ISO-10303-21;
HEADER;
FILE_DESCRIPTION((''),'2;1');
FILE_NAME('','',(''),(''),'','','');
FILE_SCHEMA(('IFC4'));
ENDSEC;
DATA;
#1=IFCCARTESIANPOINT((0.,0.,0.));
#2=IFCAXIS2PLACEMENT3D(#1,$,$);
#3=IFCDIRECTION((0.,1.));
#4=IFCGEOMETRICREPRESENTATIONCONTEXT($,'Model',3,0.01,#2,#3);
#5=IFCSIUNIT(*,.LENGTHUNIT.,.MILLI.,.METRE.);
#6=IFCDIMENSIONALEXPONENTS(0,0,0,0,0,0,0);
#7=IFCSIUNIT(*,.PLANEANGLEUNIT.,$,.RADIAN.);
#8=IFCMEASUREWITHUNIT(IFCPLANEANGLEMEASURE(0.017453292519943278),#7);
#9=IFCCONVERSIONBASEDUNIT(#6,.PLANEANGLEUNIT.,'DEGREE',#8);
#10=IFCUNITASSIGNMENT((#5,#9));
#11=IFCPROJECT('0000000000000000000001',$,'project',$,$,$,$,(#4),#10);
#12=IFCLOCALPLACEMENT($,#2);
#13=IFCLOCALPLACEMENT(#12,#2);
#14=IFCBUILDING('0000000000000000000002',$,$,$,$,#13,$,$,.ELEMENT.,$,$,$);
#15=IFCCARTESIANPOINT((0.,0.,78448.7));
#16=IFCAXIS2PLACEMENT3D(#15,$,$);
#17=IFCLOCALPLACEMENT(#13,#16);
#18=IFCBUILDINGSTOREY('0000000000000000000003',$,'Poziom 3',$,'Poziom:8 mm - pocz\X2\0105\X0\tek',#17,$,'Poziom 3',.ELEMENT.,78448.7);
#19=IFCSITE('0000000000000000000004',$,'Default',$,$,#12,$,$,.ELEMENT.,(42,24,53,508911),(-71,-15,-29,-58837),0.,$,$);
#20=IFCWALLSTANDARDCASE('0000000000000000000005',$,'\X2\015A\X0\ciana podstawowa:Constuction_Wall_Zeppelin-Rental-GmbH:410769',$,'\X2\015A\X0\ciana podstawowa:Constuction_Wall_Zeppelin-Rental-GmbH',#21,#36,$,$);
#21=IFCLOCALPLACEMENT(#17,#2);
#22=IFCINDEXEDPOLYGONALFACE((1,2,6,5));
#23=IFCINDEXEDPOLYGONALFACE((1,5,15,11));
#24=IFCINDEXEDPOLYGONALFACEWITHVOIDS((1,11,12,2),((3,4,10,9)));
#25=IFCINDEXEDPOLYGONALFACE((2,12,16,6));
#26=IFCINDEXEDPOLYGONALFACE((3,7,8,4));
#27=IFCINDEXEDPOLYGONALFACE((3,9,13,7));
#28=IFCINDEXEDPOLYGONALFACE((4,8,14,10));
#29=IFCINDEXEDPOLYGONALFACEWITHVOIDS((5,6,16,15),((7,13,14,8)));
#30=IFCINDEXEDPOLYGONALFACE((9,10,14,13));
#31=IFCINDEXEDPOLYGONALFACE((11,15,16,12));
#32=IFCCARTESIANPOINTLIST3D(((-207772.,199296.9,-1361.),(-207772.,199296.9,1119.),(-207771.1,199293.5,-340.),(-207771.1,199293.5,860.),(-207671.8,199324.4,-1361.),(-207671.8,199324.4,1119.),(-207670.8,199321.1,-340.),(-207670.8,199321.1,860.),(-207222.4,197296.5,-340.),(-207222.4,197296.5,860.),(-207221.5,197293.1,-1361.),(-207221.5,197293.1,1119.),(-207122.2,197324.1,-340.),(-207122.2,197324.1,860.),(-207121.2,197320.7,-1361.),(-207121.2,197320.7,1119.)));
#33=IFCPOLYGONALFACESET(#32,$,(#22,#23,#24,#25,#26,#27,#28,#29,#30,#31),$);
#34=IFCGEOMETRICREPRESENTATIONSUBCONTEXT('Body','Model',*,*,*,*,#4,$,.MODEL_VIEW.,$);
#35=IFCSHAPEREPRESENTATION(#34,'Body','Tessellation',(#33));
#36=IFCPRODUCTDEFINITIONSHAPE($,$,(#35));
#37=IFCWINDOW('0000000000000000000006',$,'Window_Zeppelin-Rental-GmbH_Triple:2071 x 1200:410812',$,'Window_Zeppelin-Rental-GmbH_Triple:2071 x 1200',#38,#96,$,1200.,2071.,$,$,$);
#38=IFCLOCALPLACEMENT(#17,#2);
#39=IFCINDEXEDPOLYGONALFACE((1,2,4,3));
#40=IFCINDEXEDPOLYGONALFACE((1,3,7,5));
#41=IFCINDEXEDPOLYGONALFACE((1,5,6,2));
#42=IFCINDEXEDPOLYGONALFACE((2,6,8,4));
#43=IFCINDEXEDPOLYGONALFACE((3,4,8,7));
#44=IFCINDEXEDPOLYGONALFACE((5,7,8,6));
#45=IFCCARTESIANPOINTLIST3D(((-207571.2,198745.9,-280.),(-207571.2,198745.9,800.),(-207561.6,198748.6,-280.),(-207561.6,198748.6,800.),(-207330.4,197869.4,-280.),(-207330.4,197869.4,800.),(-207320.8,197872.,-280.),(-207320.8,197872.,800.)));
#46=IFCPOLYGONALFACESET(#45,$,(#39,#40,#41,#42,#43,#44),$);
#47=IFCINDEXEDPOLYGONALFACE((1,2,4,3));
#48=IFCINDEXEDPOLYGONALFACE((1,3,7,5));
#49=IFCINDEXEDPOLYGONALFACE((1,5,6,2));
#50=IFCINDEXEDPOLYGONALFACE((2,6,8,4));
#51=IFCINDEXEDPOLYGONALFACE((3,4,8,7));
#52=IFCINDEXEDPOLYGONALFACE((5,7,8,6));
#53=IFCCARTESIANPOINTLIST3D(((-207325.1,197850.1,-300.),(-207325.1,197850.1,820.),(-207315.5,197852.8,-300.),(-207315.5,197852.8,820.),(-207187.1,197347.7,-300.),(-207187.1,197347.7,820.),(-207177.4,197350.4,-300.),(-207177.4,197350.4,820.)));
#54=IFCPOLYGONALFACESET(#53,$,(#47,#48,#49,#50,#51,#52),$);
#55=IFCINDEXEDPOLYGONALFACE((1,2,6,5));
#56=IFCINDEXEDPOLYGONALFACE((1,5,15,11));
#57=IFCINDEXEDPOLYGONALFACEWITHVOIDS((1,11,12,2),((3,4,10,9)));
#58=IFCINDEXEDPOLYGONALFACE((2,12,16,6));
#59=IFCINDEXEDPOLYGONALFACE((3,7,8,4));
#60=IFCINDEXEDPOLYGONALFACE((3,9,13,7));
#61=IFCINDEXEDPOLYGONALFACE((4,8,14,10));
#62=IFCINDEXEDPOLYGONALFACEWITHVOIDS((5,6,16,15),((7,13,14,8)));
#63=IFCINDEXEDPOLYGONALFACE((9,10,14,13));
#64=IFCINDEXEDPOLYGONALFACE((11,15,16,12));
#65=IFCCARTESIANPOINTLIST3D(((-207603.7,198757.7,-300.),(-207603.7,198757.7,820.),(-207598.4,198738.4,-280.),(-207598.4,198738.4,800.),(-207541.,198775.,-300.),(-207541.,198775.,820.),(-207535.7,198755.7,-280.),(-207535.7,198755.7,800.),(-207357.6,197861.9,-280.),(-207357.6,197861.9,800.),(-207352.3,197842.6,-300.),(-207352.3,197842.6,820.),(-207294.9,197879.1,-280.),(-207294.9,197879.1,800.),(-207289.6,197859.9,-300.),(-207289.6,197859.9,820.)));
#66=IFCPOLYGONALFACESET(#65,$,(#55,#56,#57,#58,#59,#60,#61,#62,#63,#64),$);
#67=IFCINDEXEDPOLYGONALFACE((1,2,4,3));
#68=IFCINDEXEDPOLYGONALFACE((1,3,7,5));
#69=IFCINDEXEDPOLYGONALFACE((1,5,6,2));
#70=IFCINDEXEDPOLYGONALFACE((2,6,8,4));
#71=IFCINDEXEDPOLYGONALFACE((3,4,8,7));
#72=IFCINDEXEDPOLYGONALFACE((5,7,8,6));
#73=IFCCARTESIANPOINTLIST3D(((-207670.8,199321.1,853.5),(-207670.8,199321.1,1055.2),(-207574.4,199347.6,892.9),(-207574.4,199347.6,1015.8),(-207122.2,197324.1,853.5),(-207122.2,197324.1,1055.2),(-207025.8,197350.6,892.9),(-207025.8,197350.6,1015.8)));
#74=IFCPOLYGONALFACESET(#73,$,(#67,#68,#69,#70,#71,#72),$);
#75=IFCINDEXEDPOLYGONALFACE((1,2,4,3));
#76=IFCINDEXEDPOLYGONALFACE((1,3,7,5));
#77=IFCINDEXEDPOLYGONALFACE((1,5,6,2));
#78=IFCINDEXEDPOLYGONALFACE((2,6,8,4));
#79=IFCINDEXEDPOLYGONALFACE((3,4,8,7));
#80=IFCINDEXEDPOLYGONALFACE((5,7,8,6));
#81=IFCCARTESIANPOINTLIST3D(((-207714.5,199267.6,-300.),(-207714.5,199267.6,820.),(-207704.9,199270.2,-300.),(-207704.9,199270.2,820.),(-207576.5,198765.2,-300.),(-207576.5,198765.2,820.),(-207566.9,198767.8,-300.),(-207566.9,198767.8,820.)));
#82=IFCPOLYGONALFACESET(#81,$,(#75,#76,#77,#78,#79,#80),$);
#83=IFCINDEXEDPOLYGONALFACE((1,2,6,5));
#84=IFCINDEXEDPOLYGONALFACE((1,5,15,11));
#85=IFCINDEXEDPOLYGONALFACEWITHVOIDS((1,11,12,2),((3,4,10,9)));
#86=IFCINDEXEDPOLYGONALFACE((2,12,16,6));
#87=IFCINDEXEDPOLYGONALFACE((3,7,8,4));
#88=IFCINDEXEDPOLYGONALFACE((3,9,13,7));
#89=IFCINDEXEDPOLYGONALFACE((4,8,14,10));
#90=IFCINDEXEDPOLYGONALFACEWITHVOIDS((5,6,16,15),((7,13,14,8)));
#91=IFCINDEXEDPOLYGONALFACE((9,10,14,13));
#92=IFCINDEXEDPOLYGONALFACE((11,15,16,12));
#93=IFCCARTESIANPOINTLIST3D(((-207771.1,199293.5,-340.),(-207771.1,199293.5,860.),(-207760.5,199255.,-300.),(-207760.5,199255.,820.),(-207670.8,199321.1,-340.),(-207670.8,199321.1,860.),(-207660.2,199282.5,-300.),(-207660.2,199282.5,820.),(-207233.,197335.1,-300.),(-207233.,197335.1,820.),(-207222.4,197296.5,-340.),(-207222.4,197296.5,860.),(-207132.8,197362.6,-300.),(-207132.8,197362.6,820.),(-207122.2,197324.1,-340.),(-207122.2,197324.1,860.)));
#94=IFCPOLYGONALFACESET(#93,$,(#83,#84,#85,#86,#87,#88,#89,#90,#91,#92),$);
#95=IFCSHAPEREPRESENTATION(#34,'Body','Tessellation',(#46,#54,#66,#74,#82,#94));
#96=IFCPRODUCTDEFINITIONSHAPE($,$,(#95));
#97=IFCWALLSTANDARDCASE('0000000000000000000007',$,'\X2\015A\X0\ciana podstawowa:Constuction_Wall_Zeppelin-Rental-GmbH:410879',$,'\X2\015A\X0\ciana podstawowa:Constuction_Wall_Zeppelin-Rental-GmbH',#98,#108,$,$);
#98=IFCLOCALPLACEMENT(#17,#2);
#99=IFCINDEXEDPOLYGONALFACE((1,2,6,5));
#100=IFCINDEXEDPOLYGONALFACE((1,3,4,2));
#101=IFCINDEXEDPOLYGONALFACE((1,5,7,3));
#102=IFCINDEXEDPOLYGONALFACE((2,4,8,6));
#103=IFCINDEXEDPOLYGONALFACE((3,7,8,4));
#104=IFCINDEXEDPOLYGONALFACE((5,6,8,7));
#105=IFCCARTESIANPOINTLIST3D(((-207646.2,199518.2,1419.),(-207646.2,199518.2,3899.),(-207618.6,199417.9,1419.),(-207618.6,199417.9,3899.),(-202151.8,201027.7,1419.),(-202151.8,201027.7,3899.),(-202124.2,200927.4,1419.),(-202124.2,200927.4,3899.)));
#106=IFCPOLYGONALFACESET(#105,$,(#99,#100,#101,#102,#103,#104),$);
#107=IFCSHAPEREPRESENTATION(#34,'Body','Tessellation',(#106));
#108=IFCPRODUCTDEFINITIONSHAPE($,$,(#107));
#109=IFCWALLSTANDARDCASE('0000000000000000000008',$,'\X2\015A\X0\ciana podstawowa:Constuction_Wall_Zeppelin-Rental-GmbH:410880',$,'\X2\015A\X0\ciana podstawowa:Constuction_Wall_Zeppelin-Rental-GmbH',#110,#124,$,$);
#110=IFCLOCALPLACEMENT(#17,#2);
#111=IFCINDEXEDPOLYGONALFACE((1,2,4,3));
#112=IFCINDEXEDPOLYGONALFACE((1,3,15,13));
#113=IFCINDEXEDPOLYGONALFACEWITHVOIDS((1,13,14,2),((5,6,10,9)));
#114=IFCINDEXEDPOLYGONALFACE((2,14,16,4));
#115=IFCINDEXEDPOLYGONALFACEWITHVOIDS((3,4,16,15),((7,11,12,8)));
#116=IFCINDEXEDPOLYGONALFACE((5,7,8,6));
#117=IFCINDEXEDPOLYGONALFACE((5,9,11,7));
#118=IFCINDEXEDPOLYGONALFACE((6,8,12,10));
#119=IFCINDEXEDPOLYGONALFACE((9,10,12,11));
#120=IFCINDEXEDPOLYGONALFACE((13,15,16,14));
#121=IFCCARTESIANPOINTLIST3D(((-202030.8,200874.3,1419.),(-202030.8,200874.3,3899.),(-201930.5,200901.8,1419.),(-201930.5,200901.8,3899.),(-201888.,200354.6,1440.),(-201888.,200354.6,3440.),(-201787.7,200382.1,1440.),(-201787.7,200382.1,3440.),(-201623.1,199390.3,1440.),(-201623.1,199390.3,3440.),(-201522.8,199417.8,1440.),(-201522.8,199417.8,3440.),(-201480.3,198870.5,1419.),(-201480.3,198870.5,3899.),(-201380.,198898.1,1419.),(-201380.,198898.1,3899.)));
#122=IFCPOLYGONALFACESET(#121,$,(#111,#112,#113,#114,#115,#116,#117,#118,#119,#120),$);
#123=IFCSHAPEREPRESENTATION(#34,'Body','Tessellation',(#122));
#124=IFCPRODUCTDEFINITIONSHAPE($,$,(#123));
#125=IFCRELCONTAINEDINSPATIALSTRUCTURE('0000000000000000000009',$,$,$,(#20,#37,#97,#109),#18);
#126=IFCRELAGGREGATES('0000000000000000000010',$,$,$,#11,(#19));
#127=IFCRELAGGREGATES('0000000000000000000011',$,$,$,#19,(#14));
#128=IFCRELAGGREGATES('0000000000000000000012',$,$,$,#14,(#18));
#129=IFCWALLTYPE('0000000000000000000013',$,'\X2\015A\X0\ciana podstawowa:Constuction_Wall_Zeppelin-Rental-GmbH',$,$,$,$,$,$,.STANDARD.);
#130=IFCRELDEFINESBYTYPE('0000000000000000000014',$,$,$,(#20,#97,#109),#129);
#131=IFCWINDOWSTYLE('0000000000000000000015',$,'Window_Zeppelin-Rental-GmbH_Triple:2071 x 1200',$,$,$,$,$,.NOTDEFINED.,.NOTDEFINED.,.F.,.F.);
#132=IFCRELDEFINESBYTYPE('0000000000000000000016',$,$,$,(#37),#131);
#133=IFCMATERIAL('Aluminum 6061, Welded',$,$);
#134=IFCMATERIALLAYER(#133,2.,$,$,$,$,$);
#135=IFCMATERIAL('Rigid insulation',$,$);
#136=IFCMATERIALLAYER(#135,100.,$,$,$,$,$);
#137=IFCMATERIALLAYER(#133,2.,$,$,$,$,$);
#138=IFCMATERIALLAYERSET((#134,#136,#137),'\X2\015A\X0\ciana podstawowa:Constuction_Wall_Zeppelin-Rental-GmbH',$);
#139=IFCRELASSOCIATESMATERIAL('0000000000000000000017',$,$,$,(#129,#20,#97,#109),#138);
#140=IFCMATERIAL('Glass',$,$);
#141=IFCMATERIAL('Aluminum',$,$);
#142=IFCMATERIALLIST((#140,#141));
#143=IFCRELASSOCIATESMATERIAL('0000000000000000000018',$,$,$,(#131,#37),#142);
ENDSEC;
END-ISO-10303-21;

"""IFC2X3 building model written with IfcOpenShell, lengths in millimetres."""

from ifc_helpers import new_model, entity, si_unit, converted_unit, direction, frame, frame_2d, origin, origin_2d_with_axis, place, context, subcontext, project, spatial, polyline, rectangle, outline, extrude, source, transform, mapped, material, material_list, layer, layer_set, layer_usage, type_object, type_shapes, element, fill, save


model = new_model("IFC2X3")

# Units and contexts
model_context = context("Model", 3, precision=0.01, world=origin(), true_north=direction((0.0, 1.0)))
body_context = subcontext(model_context, "Body", "Model", "MODEL_VIEW")
ifc_project = project(units=[si_unit("LENGTHUNIT", "METRE", prefix="MILLI"), converted_unit("PLANEANGLEUNIT", "DEGREE", entity("IfcPlaneAngleMeasure", 0.017453292519943278), si_unit("PLANEANGLEUNIT", "RADIAN"), dimensions=[0, 0, 0, 0, 0, 0, 0])], contexts=[model_context])

# Site, building, storey
site_placement = place(None, origin())
site = spatial("IfcSite", under=ifc_project, at=site_placement, Name="Default", CompositionType="ELEMENT", RefLatitude=(42, 24, 53, 508911), RefLongitude=(-71, -15, -29, -58837), RefElevation=0.0)
building_placement = place(site_placement, origin())
building = spatial("IfcBuilding", under=site, at=building_placement, CompositionType="ELEMENT")
storey_placement = place(building_placement, frame((0.0, 0.0, 78448.7)))
storey = spatial("IfcBuildingStorey", under=building, at=storey_placement, Name="Poziom 3", ObjectType="Poziom:8 mm - początek", LongName="Poziom 3", CompositionType="ELEMENT", Elevation=78448.7)

# Shared definitions
ifc_material_1 = material(Name="Aluminum 6061, Welded")
ifc_layer_1 = layer(ifc_material_1, 2.0)
ifc_material_2 = material(Name="Rigid insulation")
ifc_layer_2 = layer(ifc_material_2, 100.0)
ifc_layer_3 = layer(ifc_material_1, 2.0)
ifc_layer_set = layer_set([ifc_layer_1, ifc_layer_2, ifc_layer_3], Name="Ściana podstawowa:Constuction_Wall_Zeppelin-Rental-GmbH")
wall_type_1 = type_object("IfcWallType", Name="Ściana podstawowa:Constuction_Wall_Zeppelin-Rental-GmbH", PredefinedType="STANDARD", material=ifc_layer_set)

# Shared definitions
ifc_material_3 = material(Name="Glass")
ifc_material_4 = material(Name="Aluminum")
ifc_material_list = material_list([ifc_material_3, ifc_material_4])
window_style = type_object("IfcWindowStyle", Name="Window_Zeppelin-Rental-GmbH_Triple:2071 x 1200", ConstructionType="NOTDEFINED", OperationType="NOTDEFINED", ParameterTakesPrecedence=False, Sizeable=False, material=ifc_material_list)
shared_shape_1 = source(origin(), body_context, "Body", "SweptSolid", [
    extrude(rectangle(XDim=10.0, YDim=909.0, at=origin_2d_with_axis()), frame((1035.5, 52.7, 60.0), z_axis=(0.0, 0.0, 1.0), x_axis=(0.0, -1.0, 0.0)), (0.0, 0.0, 1.0), 1080.0),
    extrude(rectangle(XDim=521.0, YDim=10.0, at=frame_2d((0.0, 0.0), x_axis=(1.0, 0.0))), frame((300.5, 52.7, 40.0), z_axis=(0.0, 0.0, 1.0), x_axis=(-1.0, 0.0, 0.0)), (0.0, 0.0, 1.0), 1120.0),
    extrude(outline(polyline([(-474.5, -560.0), (474.5, -560.0), (474.5, 560.0), (-474.5, 560.0), (-474.5, -560.0)]), holes=[polyline([(-454.5, 540.0), (454.5, 540.0), (454.5, -540.0), (-454.5, -540.0), (-454.5, 540.0)])]), frame((1035.5, 85.8, 600.0), z_axis=(0.0, -1.0, 0.0), x_axis=(1.0, 0.0, 0.0)), (0.0, 0.0, 1.0), 65.0),
    extrude(outline(polyline([(-24.0, -75.5), (83.5, -75.5), (9.6, 112.1), (-69.0, 38.9), (-24.0, -75.5)])), frame((2071.0, -48.7, 1294.4), z_axis=(-1.0, 0.0, 0.0), x_axis=(0.0, 0.930458, 0.366398)), (0.0, 0.0, 1.0), 2071.0),
    extrude(rectangle(XDim=10.0, YDim=521.0, at=frame_2d((0.0, 0.0), x_axis=(1.0, 0.0))), frame((1770.5, 52.7, 40.0), z_axis=(0.0, 0.0, 1.0), x_axis=(0.0, -1.0, 0.0)), (0.0, 0.0, 1.0), 1120.0),
    extrude(outline(polyline([(-1035.5, -600.0), (1035.5, -600.0), (1035.5, 600.0), (-1035.5, 600.0), (-1035.5, -600.0)]), holes=[polyline([(-995.5, 560.0), (995.5, 560.0), (995.5, -560.0), (-995.5, -560.0), (-995.5, 560.0)])]), frame((1035.5, 105.3, 600.0), z_axis=(0.0, -1.0, 0.0), x_axis=(1.0, 0.0, 0.0)), (0.0, 0.0, 1.0), 104.0),
])
type_shapes(window_style, [shared_shape_1])

# Wall, opening, window
ifc_layer_usage_1 = layer_usage(ifc_layer_set, "AXIS2", "NEGATIVE", 52.0)
wall_1_placement = place(storey_placement, frame((-207171.4, 197306.9, -1361.0), z_axis=(0.0, 0.0, 1.0), x_axis=(-0.264931, 0.964267, 0.0)))
wall_1 = element("IfcWallStandardCase", 1, at=wall_1_placement, inside=storey, type_object=wall_type_1, material=ifc_layer_usage_1, Name="Ściana podstawowa:Constuction_Wall_Zeppelin-Rental-GmbH:410769", ObjectType="Ściana podstawowa:Constuction_Wall_Zeppelin-Rental-GmbH", context=body_context, shape_type="SweptSolid", body=[
    extrude(rectangle(XDim=2078.0, YDim=104.0, at=frame_2d((1039.0, 0.0), x_axis=(-1.0, 0.0))), origin(), (0.0, 0.0, 1.0), 2480.0),
])
opening_1_placement = place(wall_1_placement, frame((3.5, -52.0, 1021.0)))
opening_1 = element("IfcOpeningElement", 2, at=opening_1_placement, cuts=wall_1, ObjectType="Opening", context=body_context, shape_type="SweptSolid", body=[
    extrude(rectangle(XDim=1200.0, YDim=2071.0, at=frame_2d((600.0, 1035.5), x_axis=(1.0, 0.0))), frame((0.0, 0.0, 0.0), z_axis=(0.0, 1.0, 0.0), x_axis=(0.0, 0.0, 1.0)), (0.0, 0.0, 1.0), 104.0),
])
window_1_placement = place(opening_1_placement, frame((0.0, -1.3, 0.0)))
window_1 = element("IfcWindow", 3, at=window_1_placement, inside=storey, type_object=window_style, material=ifc_material_list, Name="Window_Zeppelin-Rental-GmbH_Triple:2071 x 1200:410812", ObjectType="Window_Zeppelin-Rental-GmbH_Triple:2071 x 1200", OverallHeight=1200.0, OverallWidth=2071.0, context=body_context, shape_type="MappedRepresentation", body=[
    mapped(shared_shape_1, transform((0.0, 0.0, 0.0), scale=1.0)),
])
fill(opening_1, window_1)

# Wall
ifc_layer_usage_2 = layer_usage(ifc_layer_set, "AXIS2", "NEGATIVE", 52.0)
wall_2_placement = place(storey_placement, frame((-207632.4, 199468.0, 1419.0), z_axis=(0.0, 0.0, 1.0), x_axis=(0.964267, 0.264931, 0.0)))
element("IfcWallStandardCase", 4, at=wall_2_placement, inside=storey, type_object=wall_type_1, material=ifc_layer_usage_2, Name="Ściana podstawowa:Constuction_Wall_Zeppelin-Rental-GmbH:410879", ObjectType="Ściana podstawowa:Constuction_Wall_Zeppelin-Rental-GmbH", context=body_context, shape_type="SweptSolid", body=[
    extrude(rectangle(XDim=5698.0, YDim=104.0, at=frame_2d((2849.0, 0.0), x_axis=(-1.0, 0.0))), origin(), (0.0, 0.0, 1.0), 2480.0),
])

# Wall, opening
ifc_layer_usage_3 = layer_usage(ifc_layer_set, "AXIS2", "NEGATIVE", 52.0)
wall_3_placement = place(storey_placement, frame((-201980.6, 200888.1, 1419.0), z_axis=(0.0, 0.0, 1.0), x_axis=(0.264931, -0.964267, 0.0)))
wall_3 = element("IfcWallStandardCase", 5, at=wall_3_placement, inside=storey, type_object=wall_type_1, material=ifc_layer_usage_3, Name="Ściana podstawowa:Constuction_Wall_Zeppelin-Rental-GmbH:410880", ObjectType="Ściana podstawowa:Constuction_Wall_Zeppelin-Rental-GmbH", context=body_context, shape_type="SweptSolid", body=[
    extrude(rectangle(XDim=2078.0, YDim=104.0, at=frame_2d((1039.0, 0.0), x_axis=(-1.0, 0.0))), origin(), (0.0, 0.0, 1.0), 2480.0),
])
opening_2_placement = place(wall_3_placement, frame((539.0, -52.0, 21.0)))
element("IfcOpeningElement", 6, at=opening_2_placement, cuts=wall_3, ObjectType="Opening", context=body_context, shape_type="SweptSolid", body=[
    extrude(rectangle(XDim=2000.0, YDim=1000.0, at=frame_2d((1000.0, 500.0), x_axis=(1.0, 0.0))), frame((0.0, 0.0, 0.0), z_axis=(0.0, 1.0, 0.0), x_axis=(0.0, 0.0, 1.0)), (0.0, 0.0, 1.0), 104.0),
])

save(model, "model.ifc")
